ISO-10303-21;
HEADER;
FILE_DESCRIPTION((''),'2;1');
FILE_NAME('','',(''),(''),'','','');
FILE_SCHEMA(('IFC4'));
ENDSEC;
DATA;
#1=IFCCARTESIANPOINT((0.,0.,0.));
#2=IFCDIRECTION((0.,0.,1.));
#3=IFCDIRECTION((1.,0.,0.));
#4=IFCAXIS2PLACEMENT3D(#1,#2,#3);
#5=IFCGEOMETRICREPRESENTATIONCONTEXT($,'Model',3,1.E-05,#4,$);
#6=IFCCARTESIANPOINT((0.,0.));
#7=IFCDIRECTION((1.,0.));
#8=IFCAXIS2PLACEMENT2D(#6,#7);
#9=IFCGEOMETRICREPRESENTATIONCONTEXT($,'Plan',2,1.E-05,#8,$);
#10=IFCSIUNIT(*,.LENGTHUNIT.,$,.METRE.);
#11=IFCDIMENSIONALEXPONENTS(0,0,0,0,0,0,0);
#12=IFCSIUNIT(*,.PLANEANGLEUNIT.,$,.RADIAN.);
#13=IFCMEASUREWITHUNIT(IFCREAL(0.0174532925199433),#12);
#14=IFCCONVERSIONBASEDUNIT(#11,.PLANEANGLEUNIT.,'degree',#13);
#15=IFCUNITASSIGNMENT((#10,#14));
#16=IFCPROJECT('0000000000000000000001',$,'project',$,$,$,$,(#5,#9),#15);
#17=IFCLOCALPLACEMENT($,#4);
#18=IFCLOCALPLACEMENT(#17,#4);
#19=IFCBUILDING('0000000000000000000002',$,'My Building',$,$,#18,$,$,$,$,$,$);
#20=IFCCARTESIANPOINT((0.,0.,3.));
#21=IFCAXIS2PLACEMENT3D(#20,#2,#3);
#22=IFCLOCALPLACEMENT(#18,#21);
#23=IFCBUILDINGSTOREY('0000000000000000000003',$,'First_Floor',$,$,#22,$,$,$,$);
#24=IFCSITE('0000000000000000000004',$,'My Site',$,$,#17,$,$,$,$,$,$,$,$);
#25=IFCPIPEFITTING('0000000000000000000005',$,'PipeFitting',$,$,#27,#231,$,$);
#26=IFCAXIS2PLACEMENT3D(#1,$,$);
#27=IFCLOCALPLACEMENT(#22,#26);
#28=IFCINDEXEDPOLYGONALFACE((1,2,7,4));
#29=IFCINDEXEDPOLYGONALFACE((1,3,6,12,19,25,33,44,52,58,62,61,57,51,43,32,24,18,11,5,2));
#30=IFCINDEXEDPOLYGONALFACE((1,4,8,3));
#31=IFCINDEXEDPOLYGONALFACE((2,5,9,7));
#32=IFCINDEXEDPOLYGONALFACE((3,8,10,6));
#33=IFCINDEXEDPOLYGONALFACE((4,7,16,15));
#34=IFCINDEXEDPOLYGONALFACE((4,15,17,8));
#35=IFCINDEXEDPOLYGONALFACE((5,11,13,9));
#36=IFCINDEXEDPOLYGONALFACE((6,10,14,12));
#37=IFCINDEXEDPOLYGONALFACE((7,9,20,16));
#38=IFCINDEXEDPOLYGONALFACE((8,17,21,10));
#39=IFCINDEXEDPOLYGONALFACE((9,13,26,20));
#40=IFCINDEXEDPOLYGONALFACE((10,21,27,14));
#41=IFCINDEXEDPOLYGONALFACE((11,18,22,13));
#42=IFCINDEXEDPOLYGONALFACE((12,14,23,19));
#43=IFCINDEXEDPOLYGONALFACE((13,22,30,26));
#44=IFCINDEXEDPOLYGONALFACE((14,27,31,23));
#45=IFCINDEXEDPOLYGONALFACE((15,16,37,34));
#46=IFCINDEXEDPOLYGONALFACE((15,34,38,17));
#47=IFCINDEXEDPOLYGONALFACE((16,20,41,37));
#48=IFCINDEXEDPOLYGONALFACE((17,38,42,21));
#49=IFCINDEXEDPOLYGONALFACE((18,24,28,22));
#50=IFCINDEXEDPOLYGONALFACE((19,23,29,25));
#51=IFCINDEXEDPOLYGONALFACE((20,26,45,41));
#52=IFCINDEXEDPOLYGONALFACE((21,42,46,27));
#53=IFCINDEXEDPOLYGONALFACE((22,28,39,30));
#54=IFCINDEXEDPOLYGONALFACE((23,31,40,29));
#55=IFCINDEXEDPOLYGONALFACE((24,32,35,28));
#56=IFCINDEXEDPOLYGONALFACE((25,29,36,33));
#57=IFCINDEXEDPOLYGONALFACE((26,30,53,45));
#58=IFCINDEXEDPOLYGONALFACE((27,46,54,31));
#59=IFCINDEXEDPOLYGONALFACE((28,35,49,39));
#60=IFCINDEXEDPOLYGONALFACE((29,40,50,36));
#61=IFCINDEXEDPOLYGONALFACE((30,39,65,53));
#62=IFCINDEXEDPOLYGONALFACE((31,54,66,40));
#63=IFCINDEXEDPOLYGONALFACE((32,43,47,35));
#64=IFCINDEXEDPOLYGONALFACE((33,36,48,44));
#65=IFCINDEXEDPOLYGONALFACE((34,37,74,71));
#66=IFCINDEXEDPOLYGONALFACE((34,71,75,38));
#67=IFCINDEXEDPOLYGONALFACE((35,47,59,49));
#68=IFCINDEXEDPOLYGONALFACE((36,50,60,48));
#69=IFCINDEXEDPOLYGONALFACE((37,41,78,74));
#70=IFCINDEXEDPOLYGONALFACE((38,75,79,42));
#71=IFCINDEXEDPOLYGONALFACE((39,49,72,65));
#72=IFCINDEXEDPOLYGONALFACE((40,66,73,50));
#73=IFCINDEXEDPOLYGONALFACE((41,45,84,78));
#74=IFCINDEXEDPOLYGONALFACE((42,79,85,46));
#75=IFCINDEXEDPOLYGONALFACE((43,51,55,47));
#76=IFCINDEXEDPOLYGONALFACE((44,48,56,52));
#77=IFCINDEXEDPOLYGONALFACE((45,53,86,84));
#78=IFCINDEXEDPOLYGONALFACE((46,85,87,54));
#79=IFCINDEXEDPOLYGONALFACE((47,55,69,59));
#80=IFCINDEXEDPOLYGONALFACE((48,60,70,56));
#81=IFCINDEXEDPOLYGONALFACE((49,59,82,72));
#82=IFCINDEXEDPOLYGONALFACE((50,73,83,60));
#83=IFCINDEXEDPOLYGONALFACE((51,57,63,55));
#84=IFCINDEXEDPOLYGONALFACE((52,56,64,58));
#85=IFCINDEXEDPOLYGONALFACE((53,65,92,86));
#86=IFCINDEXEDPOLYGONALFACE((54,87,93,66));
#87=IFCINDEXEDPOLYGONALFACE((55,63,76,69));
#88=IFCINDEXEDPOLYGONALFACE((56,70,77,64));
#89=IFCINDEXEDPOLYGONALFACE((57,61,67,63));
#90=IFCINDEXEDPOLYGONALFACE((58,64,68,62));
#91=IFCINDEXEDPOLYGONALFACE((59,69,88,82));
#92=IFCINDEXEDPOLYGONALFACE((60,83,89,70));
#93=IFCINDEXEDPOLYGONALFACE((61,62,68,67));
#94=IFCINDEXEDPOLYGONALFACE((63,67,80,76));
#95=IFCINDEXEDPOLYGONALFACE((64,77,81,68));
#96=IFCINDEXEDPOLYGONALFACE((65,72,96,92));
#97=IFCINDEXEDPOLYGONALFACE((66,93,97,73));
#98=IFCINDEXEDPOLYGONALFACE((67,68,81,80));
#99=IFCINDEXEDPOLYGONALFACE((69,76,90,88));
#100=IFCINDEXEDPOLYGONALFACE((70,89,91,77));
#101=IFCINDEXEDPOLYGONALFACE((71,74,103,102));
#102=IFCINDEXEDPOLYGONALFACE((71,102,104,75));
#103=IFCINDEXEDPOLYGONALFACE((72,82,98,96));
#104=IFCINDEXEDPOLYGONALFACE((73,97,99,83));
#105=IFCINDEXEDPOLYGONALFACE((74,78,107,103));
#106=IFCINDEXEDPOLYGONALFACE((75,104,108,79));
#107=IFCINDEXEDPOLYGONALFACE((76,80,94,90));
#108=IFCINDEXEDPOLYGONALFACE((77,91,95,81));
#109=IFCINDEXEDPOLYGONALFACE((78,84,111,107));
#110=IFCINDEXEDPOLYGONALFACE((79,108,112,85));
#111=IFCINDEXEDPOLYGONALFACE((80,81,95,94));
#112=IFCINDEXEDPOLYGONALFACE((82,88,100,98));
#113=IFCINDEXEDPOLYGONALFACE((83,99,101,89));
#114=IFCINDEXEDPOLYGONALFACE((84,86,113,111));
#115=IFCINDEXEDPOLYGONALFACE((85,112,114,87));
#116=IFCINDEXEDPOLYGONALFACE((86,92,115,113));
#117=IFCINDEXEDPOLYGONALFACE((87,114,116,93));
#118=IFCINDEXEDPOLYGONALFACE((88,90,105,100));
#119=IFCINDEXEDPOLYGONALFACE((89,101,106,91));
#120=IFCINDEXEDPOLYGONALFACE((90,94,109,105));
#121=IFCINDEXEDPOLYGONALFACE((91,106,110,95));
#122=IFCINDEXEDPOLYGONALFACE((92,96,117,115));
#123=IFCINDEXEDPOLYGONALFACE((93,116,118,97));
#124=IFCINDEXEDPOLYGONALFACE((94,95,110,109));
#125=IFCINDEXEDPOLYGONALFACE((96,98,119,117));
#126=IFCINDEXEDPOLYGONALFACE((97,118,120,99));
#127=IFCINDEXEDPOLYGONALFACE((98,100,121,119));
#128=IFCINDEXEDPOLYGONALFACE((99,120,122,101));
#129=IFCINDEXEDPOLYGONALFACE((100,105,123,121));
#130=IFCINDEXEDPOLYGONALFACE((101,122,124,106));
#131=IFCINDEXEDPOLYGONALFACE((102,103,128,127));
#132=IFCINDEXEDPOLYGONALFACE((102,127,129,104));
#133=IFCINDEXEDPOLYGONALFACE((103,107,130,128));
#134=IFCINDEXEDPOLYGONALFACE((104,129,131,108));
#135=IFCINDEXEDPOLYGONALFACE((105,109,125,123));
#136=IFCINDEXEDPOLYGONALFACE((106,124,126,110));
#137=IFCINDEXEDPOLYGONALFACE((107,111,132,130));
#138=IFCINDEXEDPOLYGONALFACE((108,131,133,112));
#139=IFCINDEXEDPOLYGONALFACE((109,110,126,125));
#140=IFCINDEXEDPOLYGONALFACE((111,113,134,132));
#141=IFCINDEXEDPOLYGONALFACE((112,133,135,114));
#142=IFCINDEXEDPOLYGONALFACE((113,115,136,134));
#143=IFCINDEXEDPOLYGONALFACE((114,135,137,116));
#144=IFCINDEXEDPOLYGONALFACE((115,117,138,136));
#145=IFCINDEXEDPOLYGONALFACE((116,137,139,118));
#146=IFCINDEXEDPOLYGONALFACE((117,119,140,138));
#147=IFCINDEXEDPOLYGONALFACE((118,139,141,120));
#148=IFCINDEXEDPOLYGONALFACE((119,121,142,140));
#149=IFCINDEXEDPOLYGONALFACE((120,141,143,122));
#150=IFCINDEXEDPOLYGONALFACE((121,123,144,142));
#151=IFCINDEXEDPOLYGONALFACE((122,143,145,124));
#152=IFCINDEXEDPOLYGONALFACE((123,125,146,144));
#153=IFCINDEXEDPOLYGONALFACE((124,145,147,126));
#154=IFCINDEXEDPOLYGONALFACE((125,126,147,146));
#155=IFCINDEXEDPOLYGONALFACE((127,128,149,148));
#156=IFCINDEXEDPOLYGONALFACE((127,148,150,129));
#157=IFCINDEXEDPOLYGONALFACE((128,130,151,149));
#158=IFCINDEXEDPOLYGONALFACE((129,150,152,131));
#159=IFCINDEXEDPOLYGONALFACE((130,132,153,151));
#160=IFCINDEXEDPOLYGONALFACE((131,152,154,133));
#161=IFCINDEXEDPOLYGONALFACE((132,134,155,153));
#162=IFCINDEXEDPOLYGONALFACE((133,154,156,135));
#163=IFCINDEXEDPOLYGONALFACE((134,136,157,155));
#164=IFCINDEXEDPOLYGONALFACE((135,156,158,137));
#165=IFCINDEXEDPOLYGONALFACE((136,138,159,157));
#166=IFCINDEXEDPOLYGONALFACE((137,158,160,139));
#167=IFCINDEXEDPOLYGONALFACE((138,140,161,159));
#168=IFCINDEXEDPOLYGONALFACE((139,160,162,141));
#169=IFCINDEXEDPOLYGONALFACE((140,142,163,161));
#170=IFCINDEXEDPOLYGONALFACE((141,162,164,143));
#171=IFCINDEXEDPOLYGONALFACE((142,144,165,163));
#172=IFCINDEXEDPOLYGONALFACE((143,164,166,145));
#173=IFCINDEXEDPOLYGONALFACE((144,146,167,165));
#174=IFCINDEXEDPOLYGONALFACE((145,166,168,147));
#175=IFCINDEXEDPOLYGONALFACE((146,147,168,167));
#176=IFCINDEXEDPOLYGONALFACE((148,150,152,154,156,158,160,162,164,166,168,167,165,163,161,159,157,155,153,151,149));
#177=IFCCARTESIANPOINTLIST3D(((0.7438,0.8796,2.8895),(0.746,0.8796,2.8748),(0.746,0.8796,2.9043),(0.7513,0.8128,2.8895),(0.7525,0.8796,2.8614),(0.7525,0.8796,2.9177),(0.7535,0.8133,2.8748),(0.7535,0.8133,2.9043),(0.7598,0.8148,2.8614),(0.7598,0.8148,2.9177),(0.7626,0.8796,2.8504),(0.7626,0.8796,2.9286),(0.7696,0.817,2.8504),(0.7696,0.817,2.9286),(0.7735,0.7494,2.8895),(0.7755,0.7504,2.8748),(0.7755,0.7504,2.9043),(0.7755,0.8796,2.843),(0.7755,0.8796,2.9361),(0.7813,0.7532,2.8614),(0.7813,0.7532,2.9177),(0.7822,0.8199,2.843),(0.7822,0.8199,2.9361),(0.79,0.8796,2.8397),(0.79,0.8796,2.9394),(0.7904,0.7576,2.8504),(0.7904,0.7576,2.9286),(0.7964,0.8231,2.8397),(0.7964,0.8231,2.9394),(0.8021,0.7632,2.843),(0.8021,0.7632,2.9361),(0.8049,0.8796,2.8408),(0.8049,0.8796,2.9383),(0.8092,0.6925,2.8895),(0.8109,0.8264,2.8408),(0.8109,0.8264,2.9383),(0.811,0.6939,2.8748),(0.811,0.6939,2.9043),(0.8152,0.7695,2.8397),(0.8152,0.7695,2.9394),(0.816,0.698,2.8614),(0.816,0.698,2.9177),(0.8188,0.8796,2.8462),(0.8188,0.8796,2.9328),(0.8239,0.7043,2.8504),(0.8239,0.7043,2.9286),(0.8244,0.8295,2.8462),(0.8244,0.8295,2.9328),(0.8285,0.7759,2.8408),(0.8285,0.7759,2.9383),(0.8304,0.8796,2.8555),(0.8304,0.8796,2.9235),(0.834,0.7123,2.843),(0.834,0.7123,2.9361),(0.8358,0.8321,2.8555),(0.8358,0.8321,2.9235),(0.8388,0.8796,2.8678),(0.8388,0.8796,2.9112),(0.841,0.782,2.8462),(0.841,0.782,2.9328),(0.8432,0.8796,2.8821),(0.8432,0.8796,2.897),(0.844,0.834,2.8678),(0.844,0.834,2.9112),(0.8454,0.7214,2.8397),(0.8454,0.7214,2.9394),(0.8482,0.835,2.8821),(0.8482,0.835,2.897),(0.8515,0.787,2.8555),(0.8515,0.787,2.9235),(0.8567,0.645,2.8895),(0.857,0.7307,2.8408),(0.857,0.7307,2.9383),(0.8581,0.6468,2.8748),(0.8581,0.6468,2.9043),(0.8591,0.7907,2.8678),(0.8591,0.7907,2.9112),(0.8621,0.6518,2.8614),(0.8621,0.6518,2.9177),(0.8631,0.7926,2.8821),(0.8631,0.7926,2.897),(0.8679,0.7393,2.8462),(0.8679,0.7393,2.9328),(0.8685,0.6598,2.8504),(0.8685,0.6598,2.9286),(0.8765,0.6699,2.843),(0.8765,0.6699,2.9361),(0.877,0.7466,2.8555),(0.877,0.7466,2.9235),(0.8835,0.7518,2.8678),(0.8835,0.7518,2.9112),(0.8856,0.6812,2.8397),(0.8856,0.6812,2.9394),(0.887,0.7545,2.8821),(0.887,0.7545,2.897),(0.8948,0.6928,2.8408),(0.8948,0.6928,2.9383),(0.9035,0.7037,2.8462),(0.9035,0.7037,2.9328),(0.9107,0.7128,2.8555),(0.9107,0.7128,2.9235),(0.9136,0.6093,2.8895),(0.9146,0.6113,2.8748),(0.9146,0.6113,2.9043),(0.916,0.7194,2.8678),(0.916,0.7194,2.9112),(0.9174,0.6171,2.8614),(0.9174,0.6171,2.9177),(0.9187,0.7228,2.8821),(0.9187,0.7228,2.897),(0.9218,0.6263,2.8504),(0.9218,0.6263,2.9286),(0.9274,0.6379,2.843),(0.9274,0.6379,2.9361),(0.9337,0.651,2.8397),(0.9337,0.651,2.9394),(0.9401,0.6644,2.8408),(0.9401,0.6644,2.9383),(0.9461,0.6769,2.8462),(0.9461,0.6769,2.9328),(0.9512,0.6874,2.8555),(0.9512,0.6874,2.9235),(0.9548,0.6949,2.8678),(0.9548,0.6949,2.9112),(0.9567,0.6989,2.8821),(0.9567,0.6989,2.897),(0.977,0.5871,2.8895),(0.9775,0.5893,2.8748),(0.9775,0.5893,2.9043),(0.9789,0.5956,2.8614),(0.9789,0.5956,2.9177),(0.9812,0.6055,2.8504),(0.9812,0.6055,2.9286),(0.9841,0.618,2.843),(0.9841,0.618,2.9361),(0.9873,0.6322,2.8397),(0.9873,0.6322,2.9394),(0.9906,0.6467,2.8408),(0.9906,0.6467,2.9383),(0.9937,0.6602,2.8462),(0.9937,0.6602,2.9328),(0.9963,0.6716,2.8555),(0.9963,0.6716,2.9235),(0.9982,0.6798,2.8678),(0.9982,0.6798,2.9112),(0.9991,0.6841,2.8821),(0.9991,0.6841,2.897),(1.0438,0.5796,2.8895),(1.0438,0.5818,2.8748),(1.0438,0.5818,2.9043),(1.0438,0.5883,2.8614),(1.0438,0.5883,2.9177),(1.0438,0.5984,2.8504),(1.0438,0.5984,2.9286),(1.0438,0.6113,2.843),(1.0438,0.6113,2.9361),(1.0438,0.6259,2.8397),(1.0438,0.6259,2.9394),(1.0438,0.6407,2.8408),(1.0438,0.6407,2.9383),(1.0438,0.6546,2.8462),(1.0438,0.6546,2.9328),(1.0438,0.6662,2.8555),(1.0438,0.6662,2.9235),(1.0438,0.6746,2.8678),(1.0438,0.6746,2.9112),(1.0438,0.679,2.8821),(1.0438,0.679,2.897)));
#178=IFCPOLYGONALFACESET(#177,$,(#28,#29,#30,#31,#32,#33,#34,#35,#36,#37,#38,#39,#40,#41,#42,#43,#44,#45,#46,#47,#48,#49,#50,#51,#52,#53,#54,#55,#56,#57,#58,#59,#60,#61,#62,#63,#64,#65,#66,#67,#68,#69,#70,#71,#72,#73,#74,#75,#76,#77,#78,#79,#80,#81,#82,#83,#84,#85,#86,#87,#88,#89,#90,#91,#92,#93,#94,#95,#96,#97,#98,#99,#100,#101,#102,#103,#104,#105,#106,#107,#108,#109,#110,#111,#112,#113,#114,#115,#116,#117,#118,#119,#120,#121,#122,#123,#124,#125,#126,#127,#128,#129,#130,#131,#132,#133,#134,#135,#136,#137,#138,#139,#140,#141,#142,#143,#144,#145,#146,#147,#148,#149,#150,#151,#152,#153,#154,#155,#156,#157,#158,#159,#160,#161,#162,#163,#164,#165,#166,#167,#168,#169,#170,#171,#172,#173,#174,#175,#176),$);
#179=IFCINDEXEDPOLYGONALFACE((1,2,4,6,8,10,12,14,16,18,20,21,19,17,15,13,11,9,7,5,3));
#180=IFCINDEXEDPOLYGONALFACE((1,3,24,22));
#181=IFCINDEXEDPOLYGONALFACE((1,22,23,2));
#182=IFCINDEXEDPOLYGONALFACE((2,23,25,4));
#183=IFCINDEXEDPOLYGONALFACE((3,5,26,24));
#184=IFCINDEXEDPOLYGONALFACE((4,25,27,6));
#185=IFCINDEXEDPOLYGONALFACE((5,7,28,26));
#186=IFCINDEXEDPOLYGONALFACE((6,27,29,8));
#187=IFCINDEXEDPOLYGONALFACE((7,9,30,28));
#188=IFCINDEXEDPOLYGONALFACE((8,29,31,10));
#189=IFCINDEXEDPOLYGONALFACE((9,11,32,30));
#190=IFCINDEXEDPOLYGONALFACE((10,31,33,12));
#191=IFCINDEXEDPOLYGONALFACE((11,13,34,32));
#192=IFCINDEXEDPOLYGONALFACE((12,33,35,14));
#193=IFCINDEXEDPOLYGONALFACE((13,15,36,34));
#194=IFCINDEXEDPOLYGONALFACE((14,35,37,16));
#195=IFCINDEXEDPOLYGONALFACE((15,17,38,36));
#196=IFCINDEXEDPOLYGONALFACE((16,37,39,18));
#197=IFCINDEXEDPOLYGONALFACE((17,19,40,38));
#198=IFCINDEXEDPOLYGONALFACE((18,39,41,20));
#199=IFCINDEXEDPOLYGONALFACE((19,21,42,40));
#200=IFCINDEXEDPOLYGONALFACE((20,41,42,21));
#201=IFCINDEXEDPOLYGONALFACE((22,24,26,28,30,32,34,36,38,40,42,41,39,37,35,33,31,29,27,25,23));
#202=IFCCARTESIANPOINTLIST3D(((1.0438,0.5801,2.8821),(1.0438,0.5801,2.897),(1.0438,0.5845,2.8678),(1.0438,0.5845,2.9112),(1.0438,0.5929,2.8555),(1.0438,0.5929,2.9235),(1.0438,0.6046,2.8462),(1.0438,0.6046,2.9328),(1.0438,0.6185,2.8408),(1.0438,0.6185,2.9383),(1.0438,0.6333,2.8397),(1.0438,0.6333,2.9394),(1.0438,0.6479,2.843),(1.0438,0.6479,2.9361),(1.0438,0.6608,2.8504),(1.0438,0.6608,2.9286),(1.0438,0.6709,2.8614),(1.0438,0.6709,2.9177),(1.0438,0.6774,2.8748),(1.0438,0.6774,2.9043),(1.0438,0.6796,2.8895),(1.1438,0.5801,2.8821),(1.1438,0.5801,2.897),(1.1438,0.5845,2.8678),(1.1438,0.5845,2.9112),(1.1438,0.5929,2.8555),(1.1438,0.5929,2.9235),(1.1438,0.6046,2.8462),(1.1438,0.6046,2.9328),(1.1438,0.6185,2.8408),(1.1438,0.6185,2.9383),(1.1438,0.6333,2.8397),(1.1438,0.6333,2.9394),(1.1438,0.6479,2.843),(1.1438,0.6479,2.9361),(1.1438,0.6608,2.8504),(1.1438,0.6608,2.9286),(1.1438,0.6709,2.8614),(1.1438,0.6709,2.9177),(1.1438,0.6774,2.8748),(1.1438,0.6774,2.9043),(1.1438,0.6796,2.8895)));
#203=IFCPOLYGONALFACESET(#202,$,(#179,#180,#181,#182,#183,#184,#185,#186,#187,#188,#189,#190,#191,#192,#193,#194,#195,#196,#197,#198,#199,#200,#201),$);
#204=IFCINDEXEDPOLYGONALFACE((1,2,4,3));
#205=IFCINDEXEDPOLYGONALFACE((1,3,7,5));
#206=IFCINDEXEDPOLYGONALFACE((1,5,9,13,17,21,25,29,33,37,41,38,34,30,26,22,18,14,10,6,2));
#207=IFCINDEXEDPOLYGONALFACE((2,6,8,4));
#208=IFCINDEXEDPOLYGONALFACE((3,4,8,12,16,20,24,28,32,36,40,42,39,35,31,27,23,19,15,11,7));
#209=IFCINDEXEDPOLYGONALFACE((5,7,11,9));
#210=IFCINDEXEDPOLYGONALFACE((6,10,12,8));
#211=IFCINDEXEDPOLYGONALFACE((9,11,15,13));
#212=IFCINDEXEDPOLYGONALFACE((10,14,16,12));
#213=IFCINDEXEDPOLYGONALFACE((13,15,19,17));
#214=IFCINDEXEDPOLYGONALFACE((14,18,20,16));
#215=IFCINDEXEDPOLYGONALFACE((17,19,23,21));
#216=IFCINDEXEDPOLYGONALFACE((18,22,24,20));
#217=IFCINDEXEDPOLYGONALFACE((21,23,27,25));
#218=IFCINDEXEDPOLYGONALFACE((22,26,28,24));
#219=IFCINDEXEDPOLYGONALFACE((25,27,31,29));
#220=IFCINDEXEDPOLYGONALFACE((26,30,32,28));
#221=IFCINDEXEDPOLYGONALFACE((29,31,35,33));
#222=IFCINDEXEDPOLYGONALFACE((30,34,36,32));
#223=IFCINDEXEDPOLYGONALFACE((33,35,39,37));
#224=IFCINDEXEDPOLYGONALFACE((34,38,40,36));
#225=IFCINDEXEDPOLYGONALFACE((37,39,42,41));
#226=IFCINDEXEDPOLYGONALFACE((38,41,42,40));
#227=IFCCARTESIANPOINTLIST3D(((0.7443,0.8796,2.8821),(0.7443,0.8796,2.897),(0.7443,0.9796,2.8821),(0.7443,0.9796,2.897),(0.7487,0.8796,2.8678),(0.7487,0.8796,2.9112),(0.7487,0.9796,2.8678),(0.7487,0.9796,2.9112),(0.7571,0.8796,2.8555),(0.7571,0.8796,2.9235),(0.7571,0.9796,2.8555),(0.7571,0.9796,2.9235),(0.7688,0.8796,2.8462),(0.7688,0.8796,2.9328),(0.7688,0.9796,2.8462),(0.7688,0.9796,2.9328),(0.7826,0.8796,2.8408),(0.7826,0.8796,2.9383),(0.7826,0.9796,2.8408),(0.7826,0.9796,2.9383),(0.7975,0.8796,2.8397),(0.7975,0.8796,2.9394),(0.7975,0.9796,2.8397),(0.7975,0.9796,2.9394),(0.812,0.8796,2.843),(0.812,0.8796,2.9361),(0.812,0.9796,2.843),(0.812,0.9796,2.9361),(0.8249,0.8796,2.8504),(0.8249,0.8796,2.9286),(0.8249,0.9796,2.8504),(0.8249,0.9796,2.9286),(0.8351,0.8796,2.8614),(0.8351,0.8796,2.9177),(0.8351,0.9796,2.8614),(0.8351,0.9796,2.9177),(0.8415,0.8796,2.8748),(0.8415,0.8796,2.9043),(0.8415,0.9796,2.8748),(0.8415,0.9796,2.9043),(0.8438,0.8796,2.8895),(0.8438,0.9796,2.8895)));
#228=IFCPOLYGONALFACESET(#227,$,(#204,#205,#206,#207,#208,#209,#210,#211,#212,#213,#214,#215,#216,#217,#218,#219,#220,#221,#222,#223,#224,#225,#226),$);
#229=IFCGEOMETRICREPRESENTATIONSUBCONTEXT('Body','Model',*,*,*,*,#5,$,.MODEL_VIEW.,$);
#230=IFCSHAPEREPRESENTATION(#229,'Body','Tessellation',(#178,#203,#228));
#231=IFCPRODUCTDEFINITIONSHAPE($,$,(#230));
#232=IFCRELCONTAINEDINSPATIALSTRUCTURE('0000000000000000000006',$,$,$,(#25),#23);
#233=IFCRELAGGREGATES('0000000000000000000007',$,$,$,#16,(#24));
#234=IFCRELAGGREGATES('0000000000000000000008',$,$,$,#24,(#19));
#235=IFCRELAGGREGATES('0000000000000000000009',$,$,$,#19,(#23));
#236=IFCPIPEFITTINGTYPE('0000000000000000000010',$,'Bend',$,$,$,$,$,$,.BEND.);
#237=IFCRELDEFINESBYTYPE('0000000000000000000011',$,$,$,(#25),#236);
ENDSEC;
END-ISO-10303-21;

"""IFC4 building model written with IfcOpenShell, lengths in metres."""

from ifc_helpers import new_model, entity, si_unit, converted_unit, frame, origin_with_axes, origin_2d_with_axis, place, context, subcontext, project, spatial, circle, extrude, source, transform, mapped, type_object, type_shapes, element, save


model = new_model("IFC4")

# Units and contexts
model_context = context("Model", 3, precision=1e-05, world=origin_with_axes())
plan_context = context("Plan", 2, precision=1e-05, world=origin_2d_with_axis())
body_context = subcontext(model_context, "Body", "Model", "MODEL_VIEW")
ifc_project = project(units=[si_unit("LENGTHUNIT", "METRE"), converted_unit("PLANEANGLEUNIT", "degree", entity("IfcReal", 0.0174532925199433), si_unit("PLANEANGLEUNIT", "RADIAN"), dimensions=[0, 0, 0, 0, 0, 0, 0])], contexts=[model_context, plan_context])

# Site, building, storey
site_placement = place(None, origin_with_axes())
site = spatial("IfcSite", under=ifc_project, at=site_placement, Name="My Site")
building_placement = place(site_placement, origin_with_axes())
building = spatial("IfcBuilding", under=site, at=building_placement, Name="My Building")
storey_placement = place(building_placement, frame((0.0, 0.0, 3.0), z_axis=(0.0, 0.0, 1.0), x_axis=(1.0, 0.0, 0.0)))
storey = spatial("IfcBuildingStorey", under=building, at=storey_placement, Name="First_Floor")

# Pipe fitting
pipe_fitting_type = type_object("IfcPipeFittingType", Name="Bend", PredefinedType="BEND")
shared_shape = source(origin_with_axes(), body_context, "Body", "SolidModel", [
    entity("IfcSweptDiskSolid", entity("IfcIndexedPolyCurve", entity("IfcCartesianPointList3D", [[0.0, 0.0, -0.1], [0.0732, 0.0, -0.2768], [0.25, 0.0, -0.35]]), [entity("IfcArcIndex", [1, 2, 3])]), 0.05),
    extrude(circle(Radius=0.05), origin_with_axes(), (0.0, 0.0, -1.0), 0.1),
    extrude(circle(Radius=0.05), frame((0.25, 0.0, -0.35), z_axis=(1.0, 0.0, 0.0), x_axis=(0.0, 0.0, 1.0)), (0.0, 0.0, 1.0), 0.1),
])
type_shapes(pipe_fitting_type, [shared_shape])
pipe_fitting_placement = place(storey_placement, frame((1.1438, 0.6296, 2.8895), z_axis=(1.0, 0.000001, 0.0), x_axis=(-0.000001, 1.0, 0.0)))
element("IfcPipeFitting", 1, at=pipe_fitting_placement, inside=storey, type_object=pipe_fitting_type, Name="PipeFitting", context=body_context, shape_type="MappedRepresentation", body=[
    mapped(shared_shape, transform((0.0, 0.0, 0.0), x_axis=(1.0, 0.0, 0.0), y_axis=(0.0, 1.0, 0.0), z_axis=(0.0, 0.0, 1.0), scale=1.0)),
])

save(model, "model.ifc")
